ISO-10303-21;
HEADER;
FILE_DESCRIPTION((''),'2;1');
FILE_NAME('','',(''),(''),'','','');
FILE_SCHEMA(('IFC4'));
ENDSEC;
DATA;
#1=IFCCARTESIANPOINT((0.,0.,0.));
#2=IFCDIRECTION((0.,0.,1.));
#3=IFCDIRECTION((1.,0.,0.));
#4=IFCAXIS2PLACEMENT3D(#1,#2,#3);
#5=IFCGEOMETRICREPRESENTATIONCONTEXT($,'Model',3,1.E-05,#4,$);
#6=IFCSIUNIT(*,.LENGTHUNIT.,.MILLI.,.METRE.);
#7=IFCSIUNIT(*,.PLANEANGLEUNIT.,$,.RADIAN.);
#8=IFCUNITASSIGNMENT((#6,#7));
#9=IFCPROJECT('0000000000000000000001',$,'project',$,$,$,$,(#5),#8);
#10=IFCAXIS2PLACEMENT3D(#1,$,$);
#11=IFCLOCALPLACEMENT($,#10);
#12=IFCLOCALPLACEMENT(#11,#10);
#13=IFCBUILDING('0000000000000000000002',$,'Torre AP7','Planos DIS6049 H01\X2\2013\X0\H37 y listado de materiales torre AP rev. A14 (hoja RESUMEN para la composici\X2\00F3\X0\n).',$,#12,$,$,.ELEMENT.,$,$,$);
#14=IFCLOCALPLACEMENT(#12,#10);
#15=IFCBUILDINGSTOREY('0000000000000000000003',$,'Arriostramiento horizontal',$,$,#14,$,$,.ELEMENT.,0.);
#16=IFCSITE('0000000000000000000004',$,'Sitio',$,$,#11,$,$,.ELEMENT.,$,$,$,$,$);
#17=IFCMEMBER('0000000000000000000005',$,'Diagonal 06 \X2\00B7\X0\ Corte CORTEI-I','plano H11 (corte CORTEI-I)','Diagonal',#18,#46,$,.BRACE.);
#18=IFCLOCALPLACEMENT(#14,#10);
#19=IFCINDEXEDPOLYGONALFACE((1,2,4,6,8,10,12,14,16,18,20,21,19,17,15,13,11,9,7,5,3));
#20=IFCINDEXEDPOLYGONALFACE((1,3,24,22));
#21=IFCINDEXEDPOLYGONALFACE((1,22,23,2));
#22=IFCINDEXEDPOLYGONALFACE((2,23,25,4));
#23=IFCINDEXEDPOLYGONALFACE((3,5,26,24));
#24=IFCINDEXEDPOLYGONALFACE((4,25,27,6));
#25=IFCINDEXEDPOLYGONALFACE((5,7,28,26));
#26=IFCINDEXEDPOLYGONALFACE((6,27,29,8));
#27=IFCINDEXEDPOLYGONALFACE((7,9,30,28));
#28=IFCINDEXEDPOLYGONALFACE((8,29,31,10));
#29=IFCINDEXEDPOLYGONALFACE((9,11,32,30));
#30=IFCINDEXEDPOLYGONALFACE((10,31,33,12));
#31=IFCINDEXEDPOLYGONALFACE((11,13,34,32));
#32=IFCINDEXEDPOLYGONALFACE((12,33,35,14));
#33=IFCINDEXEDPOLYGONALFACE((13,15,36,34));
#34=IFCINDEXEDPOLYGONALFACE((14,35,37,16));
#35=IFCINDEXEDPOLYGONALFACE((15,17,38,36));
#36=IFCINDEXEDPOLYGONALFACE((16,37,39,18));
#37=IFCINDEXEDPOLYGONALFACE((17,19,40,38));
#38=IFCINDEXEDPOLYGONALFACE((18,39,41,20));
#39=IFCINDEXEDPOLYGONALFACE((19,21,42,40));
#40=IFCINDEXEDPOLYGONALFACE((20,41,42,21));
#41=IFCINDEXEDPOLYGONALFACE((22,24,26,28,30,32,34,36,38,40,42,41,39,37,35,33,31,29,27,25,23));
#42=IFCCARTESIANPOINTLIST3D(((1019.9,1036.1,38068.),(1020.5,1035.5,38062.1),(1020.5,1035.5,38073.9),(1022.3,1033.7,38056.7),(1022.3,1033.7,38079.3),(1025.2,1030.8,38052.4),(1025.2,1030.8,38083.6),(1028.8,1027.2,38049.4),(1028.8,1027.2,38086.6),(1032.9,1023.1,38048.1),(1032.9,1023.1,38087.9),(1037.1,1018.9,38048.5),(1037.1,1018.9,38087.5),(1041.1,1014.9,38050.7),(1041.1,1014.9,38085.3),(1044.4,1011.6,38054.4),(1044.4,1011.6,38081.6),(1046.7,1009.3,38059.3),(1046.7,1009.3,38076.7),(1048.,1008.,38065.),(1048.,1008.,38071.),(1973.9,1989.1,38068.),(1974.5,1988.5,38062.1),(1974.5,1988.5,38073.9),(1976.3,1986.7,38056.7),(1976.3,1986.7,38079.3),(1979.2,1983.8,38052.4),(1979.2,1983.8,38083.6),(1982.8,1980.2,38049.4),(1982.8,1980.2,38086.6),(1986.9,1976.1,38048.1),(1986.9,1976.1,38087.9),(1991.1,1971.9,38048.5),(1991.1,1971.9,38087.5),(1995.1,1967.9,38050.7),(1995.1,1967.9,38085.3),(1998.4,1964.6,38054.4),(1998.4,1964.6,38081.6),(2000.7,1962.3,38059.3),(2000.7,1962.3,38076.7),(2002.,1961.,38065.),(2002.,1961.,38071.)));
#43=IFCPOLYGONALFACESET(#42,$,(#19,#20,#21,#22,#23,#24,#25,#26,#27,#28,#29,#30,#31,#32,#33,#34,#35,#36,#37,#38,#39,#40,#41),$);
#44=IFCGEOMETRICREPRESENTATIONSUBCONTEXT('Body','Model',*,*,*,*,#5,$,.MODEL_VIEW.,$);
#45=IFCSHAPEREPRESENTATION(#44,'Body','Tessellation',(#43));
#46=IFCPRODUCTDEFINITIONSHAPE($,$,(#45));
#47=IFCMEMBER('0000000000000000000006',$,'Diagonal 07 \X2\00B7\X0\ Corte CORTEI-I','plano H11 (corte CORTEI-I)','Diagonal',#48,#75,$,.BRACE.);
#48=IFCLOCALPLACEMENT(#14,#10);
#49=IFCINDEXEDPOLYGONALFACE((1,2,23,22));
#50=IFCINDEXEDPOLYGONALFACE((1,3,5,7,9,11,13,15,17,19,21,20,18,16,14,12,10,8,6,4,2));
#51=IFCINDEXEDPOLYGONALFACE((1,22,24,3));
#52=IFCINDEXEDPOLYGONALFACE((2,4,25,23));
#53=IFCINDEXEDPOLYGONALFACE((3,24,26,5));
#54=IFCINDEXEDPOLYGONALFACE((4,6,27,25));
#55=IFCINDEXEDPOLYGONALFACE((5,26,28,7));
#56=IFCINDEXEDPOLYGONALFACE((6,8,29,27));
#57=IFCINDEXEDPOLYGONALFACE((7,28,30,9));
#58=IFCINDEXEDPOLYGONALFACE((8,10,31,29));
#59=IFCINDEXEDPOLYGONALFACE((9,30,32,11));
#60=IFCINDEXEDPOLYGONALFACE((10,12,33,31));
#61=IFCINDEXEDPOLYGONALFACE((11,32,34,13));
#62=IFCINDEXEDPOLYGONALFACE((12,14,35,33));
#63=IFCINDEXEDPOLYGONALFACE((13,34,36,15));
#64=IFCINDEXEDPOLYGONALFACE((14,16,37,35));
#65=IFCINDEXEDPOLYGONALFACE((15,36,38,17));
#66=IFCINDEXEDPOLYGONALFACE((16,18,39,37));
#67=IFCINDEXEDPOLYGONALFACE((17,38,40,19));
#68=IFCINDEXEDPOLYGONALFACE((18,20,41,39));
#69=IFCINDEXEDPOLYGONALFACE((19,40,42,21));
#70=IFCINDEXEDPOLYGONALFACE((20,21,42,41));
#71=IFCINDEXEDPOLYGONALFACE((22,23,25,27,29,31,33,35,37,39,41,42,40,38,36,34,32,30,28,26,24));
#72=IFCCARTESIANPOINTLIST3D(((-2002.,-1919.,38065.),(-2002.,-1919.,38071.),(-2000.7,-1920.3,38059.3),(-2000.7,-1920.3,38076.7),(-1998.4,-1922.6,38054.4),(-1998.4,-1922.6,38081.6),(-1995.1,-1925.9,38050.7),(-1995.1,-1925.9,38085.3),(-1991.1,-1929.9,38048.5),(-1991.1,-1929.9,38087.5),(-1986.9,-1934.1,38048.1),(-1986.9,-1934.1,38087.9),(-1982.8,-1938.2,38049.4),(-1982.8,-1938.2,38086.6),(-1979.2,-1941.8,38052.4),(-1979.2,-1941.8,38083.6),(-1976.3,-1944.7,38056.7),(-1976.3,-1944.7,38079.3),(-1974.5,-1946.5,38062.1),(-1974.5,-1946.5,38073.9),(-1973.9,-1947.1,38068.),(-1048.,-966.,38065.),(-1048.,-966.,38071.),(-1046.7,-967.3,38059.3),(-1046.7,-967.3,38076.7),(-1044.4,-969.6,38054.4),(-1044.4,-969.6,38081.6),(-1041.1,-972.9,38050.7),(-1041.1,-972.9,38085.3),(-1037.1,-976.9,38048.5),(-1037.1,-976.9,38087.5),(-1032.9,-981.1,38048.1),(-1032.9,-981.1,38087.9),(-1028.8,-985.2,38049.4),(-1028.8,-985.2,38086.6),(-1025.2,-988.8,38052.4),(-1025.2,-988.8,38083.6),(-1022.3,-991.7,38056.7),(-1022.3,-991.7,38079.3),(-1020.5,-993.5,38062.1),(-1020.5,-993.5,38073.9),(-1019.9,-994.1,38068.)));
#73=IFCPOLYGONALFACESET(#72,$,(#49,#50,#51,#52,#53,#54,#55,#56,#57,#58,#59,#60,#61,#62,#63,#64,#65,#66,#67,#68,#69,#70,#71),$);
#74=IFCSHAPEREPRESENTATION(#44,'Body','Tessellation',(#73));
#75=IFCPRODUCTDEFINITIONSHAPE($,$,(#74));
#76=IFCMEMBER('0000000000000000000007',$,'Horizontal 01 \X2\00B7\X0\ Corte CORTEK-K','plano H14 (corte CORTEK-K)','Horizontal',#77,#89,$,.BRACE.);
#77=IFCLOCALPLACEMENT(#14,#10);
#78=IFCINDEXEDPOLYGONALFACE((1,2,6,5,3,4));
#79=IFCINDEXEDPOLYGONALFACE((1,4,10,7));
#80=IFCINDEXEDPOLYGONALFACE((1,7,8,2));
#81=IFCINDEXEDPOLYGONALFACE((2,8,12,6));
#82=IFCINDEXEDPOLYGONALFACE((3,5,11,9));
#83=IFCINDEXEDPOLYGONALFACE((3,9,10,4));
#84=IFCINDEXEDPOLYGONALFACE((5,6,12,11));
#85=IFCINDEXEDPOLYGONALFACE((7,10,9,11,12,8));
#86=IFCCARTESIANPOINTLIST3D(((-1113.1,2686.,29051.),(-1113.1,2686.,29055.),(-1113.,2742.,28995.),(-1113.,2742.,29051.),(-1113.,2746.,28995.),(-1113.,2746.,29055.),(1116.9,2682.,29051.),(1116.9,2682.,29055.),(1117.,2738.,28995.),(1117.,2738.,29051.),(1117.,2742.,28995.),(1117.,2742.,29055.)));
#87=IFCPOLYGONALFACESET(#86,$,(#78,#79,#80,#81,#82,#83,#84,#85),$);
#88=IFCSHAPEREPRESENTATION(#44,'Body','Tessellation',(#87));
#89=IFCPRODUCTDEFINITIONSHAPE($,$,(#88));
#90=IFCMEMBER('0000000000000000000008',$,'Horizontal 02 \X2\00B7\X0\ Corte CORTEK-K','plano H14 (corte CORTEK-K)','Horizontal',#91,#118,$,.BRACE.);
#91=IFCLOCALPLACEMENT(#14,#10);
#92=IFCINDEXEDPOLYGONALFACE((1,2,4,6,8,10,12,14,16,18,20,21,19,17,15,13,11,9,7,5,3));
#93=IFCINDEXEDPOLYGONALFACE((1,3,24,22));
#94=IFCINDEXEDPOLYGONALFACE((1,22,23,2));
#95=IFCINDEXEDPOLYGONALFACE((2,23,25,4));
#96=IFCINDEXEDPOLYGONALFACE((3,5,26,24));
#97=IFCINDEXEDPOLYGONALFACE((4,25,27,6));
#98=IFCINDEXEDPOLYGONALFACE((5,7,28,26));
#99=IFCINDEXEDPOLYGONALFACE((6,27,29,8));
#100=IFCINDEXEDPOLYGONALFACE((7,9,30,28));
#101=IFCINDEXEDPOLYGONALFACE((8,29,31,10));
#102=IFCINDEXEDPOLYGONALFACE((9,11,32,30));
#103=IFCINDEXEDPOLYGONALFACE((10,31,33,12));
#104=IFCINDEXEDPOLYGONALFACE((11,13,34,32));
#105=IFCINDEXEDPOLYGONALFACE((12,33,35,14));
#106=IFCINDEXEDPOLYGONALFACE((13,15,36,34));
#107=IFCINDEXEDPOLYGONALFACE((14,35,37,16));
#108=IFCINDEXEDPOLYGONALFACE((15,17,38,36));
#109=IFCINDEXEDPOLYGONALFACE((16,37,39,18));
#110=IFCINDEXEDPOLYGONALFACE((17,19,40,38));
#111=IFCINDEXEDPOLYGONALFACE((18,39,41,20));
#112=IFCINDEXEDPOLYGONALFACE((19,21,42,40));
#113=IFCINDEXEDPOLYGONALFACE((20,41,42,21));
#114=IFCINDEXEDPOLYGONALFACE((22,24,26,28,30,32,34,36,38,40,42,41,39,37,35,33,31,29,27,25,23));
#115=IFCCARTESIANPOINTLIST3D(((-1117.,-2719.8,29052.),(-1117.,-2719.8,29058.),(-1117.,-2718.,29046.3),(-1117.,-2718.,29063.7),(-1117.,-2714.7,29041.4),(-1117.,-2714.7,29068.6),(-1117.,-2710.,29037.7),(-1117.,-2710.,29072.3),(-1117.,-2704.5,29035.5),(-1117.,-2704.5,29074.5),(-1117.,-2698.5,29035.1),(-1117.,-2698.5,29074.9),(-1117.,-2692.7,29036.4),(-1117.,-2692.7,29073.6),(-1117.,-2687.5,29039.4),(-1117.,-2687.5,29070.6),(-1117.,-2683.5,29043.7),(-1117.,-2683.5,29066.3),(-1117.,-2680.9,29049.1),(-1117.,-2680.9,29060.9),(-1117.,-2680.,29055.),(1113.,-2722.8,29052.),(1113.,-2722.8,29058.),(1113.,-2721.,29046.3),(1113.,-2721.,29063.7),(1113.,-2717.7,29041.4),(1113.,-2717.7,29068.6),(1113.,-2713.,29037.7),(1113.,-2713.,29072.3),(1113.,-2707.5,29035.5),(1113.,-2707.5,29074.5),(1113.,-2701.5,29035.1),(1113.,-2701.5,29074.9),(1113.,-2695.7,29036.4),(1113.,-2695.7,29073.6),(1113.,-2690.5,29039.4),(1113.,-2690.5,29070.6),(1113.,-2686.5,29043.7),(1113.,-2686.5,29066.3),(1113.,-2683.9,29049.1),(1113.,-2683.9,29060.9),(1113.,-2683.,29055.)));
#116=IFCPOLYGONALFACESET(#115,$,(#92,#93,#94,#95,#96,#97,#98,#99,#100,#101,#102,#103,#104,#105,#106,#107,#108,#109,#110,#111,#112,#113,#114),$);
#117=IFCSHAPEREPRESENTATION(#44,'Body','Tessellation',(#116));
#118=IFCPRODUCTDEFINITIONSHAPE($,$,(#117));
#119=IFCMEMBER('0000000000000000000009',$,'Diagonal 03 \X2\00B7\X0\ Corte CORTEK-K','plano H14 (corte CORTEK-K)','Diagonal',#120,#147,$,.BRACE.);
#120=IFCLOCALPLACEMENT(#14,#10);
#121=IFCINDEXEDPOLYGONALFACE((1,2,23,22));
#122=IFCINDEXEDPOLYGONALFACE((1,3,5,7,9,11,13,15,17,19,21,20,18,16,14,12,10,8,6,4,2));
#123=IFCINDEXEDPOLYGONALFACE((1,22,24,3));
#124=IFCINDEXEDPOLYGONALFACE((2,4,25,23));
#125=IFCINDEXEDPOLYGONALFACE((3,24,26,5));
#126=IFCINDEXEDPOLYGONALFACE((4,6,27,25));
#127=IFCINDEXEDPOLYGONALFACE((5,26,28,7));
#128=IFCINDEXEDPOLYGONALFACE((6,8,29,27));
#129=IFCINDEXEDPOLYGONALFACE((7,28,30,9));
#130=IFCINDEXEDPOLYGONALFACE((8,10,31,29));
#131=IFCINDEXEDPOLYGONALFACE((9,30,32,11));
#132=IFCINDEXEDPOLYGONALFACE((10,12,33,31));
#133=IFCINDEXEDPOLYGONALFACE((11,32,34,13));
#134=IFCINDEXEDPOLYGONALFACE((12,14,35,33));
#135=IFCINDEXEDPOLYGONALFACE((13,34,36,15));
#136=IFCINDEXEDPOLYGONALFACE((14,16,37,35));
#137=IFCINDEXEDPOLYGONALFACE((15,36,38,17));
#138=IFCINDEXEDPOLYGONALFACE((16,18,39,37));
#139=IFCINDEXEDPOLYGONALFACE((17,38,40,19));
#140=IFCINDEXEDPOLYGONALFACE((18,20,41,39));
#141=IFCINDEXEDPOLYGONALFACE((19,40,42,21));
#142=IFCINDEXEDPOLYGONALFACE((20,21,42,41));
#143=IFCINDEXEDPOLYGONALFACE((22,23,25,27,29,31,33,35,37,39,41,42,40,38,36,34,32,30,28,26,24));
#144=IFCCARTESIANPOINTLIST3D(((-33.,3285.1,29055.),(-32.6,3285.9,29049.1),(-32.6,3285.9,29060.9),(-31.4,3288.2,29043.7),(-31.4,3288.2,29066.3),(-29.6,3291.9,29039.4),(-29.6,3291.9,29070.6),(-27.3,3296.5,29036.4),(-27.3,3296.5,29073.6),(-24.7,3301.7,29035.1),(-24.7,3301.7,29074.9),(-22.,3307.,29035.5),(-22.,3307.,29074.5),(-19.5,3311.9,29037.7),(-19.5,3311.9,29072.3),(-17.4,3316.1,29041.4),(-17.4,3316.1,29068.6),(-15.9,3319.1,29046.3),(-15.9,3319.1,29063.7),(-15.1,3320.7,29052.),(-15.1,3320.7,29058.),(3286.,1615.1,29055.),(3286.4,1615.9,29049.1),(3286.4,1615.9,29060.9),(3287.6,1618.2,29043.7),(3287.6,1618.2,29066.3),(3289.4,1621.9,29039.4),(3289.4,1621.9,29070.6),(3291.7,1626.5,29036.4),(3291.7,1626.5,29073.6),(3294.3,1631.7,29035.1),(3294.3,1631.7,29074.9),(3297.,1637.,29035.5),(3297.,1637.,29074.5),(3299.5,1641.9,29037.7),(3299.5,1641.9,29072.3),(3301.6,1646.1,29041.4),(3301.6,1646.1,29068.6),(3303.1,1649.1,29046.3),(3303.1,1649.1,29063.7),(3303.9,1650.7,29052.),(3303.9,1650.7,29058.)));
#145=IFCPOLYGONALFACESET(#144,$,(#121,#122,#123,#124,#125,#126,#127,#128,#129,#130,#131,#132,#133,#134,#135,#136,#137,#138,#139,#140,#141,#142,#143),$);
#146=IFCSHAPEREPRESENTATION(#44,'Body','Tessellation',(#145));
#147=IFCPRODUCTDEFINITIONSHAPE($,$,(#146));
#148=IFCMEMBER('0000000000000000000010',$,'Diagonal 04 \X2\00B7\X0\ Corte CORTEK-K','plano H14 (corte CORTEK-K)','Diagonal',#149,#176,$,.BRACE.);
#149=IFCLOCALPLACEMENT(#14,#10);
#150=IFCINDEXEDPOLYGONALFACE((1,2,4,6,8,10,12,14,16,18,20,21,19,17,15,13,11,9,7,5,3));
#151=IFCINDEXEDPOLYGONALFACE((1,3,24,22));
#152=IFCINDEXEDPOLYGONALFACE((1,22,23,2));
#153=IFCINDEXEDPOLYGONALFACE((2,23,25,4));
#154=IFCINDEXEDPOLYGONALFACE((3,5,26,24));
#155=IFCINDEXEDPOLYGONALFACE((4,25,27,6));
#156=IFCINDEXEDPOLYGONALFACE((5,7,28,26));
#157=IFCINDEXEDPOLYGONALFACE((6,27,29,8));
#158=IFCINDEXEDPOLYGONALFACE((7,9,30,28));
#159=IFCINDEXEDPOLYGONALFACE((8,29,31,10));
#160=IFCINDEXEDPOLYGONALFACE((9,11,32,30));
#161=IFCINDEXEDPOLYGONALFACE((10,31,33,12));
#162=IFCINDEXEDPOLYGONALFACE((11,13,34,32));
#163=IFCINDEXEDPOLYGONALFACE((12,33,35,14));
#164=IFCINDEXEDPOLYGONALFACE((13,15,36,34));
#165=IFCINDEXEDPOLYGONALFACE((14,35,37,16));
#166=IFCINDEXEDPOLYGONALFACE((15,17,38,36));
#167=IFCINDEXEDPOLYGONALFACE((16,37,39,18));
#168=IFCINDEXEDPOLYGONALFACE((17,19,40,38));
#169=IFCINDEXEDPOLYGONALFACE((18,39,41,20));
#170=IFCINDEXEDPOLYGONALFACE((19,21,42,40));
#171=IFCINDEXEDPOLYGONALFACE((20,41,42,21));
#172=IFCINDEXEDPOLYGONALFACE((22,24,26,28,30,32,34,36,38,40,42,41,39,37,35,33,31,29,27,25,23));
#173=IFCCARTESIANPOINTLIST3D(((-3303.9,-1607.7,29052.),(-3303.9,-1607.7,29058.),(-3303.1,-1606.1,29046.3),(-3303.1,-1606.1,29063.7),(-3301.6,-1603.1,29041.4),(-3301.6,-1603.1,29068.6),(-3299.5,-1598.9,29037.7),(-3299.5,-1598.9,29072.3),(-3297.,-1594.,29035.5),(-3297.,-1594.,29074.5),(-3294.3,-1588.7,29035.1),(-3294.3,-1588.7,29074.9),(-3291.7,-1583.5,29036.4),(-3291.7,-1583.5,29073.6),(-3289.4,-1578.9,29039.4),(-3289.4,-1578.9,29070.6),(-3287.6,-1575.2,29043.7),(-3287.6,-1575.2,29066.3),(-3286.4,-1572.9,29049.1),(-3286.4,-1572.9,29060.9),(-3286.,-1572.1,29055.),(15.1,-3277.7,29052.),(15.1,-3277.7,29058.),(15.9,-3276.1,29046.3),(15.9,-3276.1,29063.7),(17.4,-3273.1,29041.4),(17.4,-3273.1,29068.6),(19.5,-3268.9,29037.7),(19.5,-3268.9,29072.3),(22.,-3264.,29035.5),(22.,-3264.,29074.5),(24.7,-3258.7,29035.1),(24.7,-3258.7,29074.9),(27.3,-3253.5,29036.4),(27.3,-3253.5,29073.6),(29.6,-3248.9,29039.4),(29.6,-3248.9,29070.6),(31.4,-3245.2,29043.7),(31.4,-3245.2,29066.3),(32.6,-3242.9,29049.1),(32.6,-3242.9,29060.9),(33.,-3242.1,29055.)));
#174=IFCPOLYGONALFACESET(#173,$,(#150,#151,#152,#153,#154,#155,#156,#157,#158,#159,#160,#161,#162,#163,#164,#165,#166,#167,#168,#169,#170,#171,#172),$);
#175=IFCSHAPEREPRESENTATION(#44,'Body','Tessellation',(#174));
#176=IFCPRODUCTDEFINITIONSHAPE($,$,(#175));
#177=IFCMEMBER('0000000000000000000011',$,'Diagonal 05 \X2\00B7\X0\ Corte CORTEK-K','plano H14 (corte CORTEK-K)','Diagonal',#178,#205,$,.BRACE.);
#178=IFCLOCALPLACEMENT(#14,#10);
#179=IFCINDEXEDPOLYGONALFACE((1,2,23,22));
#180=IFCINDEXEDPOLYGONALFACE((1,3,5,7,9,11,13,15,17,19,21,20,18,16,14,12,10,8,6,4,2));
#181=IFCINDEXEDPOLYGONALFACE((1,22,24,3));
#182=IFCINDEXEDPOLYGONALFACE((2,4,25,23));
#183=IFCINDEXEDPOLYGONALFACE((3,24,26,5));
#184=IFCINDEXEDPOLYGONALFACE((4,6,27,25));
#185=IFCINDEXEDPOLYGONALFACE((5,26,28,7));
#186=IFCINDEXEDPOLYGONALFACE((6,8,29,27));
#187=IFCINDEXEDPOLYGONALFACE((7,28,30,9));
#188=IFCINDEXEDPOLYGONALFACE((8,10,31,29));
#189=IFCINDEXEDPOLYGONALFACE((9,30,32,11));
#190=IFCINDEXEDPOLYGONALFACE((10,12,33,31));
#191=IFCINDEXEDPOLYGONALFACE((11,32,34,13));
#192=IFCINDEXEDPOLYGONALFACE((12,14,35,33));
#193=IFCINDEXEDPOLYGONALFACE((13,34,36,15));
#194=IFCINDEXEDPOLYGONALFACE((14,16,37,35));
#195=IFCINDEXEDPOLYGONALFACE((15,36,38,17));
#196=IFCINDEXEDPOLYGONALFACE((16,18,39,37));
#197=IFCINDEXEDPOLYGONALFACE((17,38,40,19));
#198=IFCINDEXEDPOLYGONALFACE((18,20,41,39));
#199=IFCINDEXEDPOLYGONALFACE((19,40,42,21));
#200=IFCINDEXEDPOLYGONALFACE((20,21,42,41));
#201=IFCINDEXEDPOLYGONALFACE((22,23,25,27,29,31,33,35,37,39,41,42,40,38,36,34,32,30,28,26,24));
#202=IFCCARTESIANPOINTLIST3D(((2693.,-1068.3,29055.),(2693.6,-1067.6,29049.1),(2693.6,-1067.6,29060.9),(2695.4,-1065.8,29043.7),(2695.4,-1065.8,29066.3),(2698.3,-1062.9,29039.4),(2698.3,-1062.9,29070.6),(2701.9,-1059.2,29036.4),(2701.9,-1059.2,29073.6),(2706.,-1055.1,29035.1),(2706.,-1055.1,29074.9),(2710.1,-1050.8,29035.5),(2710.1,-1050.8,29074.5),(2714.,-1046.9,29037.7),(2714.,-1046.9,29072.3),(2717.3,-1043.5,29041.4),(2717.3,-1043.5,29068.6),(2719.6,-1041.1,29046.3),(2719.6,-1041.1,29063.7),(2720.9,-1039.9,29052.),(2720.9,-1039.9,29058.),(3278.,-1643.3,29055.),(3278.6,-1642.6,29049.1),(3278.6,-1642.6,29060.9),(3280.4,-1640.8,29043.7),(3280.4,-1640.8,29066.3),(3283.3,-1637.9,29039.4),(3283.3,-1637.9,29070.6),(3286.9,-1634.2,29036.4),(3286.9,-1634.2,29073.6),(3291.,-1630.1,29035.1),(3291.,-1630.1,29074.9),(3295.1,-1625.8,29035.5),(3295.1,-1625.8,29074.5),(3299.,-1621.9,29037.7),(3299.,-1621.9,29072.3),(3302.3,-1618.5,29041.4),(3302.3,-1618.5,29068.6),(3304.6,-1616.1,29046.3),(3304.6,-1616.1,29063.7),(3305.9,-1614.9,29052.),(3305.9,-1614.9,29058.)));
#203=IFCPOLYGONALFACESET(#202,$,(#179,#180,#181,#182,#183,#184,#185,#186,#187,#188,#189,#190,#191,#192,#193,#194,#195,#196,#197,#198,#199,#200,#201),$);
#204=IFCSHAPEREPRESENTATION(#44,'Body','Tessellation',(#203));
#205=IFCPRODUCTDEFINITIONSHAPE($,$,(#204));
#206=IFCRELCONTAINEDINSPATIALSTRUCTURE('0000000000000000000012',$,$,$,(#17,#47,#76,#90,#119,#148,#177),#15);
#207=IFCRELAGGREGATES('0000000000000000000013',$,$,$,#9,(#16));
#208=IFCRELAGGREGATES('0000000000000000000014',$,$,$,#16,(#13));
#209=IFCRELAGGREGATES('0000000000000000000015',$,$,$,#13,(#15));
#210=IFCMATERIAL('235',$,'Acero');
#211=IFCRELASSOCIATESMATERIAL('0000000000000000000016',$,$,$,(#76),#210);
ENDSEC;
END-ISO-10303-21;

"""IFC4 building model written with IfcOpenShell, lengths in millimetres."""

from ifc_helpers import new_model, si_unit, frame, frame_2d, origin, origin_with_axes, place, context, subcontext, project, spatial, circle, l_section, extrude, material, element, save


model = new_model("IFC4")

# Units and contexts
model_context = context("Model", 3, precision=1e-05, world=origin_with_axes())
body_context = subcontext(model_context, "Body", "Model", "MODEL_VIEW")
ifc_project = project(units=[si_unit("LENGTHUNIT", "METRE", prefix="MILLI"), si_unit("PLANEANGLEUNIT", "RADIAN")], contexts=[model_context])

# Site, building, storey
site_placement = place(None, origin())
site = spatial("IfcSite", under=ifc_project, at=site_placement, Name="Sitio", CompositionType="ELEMENT")
building_placement = place(site_placement, origin())
building = spatial("IfcBuilding", under=site, at=building_placement, Name="Torre AP7", Description="Planos DIS6049 H01–H37 y listado de materiales torre AP rev. A14 (hoja RESUMEN para la composición).", CompositionType="ELEMENT")
storey_placement = place(building_placement, origin())
storey = spatial("IfcBuildingStorey", under=building, at=storey_placement, Name="Arriostramiento horizontal", CompositionType="ELEMENT", Elevation=0.0)

# Members
ifc_material = material(Name="235", Category="Acero")
for number, where, z_axis, x_axis, name in (
    (1, (1988.0, 1975.0, 38068.0), (-0.707477, -0.706736, 0.0), (-0.706736, 0.707477, 0.0), "Diagonal 06 · Corte CORTEI-I"),
    (2, (-1034.0, -980.0, 38068.0), (-0.707477, -0.706736, 0.0), (0.706736, -0.707477, 0.0), "Diagonal 07 · Corte CORTEI-I"),
):
    element("IfcMember", number, at=place(storey_placement, frame(where, z_axis=z_axis, x_axis=x_axis)), inside=storey, Name=name, Description="plano H11 (corte CORTEI-I)", ObjectType="Diagonal", PredefinedType="BRACE", context=body_context, shape_type="SweptSolid", body=[
        extrude(circle(Radius=20.0), None, (0.0, 0.0, 1.0), 1348.5),
    ])
member_1_placement = place(storey_placement, frame((-1113.0, 2746.0, 29055.0), z_axis=(0.999998, -0.001794, 0.0), x_axis=(-0.001794, -0.999998, 0.0)))
element("IfcMember", 3, at=member_1_placement, inside=storey, material=ifc_material, Name="Horizontal 01 · Corte CORTEK-K", Description="plano H14 (corte CORTEK-K)", ObjectType="Horizontal", PredefinedType="BRACE", context=body_context, shape_type="SweptSolid", body=[
    extrude(l_section(Depth=60.0, Width=60.0, Thickness=4.0, at=frame_2d((30.0, 30.0))), None, (0.0, 0.0, 1.0), 2230.0),
])
member_2_placement = place(storey_placement, frame((-1117.0, -2700.0, 29055.0), z_axis=(0.999999, -0.001345, 0.0), x_axis=(0.001345, 0.999999, 0.0)))
element("IfcMember", 4, at=member_2_placement, inside=storey, Name="Horizontal 02 · Corte CORTEK-K", Description="plano H14 (corte CORTEK-K)", ObjectType="Horizontal", PredefinedType="BRACE", context=body_context, shape_type="SweptSolid", body=[
    extrude(circle(Radius=20.0), None, (0.0, 0.0, 1.0), 2230.0),
])
for number, where, z_axis, x_axis, name in (
    (5, (-24.0, 3303.0, 29055.0), (0.893294, -0.449473, 0.0), (-0.449473, -0.893294, 0.0), "Diagonal 03 · Corte CORTEK-K"),
    (6, (-3295.0, -1590.0, 29055.0), (0.893294, -0.449473, 0.0), (0.449473, 0.893294, 0.0), "Diagonal 04 · Corte CORTEK-K"),
):
    element("IfcMember", number, at=place(storey_placement, frame(where, z_axis=z_axis, x_axis=x_axis)), inside=storey, Name=name, Description="plano H14 (corte CORTEK-K)", ObjectType="Diagonal", PredefinedType="BRACE", context=body_context, shape_type="SweptSolid", body=[
        extrude(circle(Radius=20.0), None, (0.0, 0.0, 1.0), 3715.5),
    ])
member_3_placement = place(storey_placement, frame((2707.0, -1054.0, 29055.0), z_axis=(0.713176, -0.700985, 0.0), x_axis=(-0.700985, -0.713176, 0.0)))
element("IfcMember", 7, at=member_3_placement, inside=storey, Name="Diagonal 05 · Corte CORTEK-K", Description="plano H14 (corte CORTEK-K)", ObjectType="Diagonal", PredefinedType="BRACE", context=body_context, shape_type="SweptSolid", body=[
    extrude(circle(Radius=20.0), None, (0.0, 0.0, 1.0), 820.3),
])

save(model, "model.ifc")
